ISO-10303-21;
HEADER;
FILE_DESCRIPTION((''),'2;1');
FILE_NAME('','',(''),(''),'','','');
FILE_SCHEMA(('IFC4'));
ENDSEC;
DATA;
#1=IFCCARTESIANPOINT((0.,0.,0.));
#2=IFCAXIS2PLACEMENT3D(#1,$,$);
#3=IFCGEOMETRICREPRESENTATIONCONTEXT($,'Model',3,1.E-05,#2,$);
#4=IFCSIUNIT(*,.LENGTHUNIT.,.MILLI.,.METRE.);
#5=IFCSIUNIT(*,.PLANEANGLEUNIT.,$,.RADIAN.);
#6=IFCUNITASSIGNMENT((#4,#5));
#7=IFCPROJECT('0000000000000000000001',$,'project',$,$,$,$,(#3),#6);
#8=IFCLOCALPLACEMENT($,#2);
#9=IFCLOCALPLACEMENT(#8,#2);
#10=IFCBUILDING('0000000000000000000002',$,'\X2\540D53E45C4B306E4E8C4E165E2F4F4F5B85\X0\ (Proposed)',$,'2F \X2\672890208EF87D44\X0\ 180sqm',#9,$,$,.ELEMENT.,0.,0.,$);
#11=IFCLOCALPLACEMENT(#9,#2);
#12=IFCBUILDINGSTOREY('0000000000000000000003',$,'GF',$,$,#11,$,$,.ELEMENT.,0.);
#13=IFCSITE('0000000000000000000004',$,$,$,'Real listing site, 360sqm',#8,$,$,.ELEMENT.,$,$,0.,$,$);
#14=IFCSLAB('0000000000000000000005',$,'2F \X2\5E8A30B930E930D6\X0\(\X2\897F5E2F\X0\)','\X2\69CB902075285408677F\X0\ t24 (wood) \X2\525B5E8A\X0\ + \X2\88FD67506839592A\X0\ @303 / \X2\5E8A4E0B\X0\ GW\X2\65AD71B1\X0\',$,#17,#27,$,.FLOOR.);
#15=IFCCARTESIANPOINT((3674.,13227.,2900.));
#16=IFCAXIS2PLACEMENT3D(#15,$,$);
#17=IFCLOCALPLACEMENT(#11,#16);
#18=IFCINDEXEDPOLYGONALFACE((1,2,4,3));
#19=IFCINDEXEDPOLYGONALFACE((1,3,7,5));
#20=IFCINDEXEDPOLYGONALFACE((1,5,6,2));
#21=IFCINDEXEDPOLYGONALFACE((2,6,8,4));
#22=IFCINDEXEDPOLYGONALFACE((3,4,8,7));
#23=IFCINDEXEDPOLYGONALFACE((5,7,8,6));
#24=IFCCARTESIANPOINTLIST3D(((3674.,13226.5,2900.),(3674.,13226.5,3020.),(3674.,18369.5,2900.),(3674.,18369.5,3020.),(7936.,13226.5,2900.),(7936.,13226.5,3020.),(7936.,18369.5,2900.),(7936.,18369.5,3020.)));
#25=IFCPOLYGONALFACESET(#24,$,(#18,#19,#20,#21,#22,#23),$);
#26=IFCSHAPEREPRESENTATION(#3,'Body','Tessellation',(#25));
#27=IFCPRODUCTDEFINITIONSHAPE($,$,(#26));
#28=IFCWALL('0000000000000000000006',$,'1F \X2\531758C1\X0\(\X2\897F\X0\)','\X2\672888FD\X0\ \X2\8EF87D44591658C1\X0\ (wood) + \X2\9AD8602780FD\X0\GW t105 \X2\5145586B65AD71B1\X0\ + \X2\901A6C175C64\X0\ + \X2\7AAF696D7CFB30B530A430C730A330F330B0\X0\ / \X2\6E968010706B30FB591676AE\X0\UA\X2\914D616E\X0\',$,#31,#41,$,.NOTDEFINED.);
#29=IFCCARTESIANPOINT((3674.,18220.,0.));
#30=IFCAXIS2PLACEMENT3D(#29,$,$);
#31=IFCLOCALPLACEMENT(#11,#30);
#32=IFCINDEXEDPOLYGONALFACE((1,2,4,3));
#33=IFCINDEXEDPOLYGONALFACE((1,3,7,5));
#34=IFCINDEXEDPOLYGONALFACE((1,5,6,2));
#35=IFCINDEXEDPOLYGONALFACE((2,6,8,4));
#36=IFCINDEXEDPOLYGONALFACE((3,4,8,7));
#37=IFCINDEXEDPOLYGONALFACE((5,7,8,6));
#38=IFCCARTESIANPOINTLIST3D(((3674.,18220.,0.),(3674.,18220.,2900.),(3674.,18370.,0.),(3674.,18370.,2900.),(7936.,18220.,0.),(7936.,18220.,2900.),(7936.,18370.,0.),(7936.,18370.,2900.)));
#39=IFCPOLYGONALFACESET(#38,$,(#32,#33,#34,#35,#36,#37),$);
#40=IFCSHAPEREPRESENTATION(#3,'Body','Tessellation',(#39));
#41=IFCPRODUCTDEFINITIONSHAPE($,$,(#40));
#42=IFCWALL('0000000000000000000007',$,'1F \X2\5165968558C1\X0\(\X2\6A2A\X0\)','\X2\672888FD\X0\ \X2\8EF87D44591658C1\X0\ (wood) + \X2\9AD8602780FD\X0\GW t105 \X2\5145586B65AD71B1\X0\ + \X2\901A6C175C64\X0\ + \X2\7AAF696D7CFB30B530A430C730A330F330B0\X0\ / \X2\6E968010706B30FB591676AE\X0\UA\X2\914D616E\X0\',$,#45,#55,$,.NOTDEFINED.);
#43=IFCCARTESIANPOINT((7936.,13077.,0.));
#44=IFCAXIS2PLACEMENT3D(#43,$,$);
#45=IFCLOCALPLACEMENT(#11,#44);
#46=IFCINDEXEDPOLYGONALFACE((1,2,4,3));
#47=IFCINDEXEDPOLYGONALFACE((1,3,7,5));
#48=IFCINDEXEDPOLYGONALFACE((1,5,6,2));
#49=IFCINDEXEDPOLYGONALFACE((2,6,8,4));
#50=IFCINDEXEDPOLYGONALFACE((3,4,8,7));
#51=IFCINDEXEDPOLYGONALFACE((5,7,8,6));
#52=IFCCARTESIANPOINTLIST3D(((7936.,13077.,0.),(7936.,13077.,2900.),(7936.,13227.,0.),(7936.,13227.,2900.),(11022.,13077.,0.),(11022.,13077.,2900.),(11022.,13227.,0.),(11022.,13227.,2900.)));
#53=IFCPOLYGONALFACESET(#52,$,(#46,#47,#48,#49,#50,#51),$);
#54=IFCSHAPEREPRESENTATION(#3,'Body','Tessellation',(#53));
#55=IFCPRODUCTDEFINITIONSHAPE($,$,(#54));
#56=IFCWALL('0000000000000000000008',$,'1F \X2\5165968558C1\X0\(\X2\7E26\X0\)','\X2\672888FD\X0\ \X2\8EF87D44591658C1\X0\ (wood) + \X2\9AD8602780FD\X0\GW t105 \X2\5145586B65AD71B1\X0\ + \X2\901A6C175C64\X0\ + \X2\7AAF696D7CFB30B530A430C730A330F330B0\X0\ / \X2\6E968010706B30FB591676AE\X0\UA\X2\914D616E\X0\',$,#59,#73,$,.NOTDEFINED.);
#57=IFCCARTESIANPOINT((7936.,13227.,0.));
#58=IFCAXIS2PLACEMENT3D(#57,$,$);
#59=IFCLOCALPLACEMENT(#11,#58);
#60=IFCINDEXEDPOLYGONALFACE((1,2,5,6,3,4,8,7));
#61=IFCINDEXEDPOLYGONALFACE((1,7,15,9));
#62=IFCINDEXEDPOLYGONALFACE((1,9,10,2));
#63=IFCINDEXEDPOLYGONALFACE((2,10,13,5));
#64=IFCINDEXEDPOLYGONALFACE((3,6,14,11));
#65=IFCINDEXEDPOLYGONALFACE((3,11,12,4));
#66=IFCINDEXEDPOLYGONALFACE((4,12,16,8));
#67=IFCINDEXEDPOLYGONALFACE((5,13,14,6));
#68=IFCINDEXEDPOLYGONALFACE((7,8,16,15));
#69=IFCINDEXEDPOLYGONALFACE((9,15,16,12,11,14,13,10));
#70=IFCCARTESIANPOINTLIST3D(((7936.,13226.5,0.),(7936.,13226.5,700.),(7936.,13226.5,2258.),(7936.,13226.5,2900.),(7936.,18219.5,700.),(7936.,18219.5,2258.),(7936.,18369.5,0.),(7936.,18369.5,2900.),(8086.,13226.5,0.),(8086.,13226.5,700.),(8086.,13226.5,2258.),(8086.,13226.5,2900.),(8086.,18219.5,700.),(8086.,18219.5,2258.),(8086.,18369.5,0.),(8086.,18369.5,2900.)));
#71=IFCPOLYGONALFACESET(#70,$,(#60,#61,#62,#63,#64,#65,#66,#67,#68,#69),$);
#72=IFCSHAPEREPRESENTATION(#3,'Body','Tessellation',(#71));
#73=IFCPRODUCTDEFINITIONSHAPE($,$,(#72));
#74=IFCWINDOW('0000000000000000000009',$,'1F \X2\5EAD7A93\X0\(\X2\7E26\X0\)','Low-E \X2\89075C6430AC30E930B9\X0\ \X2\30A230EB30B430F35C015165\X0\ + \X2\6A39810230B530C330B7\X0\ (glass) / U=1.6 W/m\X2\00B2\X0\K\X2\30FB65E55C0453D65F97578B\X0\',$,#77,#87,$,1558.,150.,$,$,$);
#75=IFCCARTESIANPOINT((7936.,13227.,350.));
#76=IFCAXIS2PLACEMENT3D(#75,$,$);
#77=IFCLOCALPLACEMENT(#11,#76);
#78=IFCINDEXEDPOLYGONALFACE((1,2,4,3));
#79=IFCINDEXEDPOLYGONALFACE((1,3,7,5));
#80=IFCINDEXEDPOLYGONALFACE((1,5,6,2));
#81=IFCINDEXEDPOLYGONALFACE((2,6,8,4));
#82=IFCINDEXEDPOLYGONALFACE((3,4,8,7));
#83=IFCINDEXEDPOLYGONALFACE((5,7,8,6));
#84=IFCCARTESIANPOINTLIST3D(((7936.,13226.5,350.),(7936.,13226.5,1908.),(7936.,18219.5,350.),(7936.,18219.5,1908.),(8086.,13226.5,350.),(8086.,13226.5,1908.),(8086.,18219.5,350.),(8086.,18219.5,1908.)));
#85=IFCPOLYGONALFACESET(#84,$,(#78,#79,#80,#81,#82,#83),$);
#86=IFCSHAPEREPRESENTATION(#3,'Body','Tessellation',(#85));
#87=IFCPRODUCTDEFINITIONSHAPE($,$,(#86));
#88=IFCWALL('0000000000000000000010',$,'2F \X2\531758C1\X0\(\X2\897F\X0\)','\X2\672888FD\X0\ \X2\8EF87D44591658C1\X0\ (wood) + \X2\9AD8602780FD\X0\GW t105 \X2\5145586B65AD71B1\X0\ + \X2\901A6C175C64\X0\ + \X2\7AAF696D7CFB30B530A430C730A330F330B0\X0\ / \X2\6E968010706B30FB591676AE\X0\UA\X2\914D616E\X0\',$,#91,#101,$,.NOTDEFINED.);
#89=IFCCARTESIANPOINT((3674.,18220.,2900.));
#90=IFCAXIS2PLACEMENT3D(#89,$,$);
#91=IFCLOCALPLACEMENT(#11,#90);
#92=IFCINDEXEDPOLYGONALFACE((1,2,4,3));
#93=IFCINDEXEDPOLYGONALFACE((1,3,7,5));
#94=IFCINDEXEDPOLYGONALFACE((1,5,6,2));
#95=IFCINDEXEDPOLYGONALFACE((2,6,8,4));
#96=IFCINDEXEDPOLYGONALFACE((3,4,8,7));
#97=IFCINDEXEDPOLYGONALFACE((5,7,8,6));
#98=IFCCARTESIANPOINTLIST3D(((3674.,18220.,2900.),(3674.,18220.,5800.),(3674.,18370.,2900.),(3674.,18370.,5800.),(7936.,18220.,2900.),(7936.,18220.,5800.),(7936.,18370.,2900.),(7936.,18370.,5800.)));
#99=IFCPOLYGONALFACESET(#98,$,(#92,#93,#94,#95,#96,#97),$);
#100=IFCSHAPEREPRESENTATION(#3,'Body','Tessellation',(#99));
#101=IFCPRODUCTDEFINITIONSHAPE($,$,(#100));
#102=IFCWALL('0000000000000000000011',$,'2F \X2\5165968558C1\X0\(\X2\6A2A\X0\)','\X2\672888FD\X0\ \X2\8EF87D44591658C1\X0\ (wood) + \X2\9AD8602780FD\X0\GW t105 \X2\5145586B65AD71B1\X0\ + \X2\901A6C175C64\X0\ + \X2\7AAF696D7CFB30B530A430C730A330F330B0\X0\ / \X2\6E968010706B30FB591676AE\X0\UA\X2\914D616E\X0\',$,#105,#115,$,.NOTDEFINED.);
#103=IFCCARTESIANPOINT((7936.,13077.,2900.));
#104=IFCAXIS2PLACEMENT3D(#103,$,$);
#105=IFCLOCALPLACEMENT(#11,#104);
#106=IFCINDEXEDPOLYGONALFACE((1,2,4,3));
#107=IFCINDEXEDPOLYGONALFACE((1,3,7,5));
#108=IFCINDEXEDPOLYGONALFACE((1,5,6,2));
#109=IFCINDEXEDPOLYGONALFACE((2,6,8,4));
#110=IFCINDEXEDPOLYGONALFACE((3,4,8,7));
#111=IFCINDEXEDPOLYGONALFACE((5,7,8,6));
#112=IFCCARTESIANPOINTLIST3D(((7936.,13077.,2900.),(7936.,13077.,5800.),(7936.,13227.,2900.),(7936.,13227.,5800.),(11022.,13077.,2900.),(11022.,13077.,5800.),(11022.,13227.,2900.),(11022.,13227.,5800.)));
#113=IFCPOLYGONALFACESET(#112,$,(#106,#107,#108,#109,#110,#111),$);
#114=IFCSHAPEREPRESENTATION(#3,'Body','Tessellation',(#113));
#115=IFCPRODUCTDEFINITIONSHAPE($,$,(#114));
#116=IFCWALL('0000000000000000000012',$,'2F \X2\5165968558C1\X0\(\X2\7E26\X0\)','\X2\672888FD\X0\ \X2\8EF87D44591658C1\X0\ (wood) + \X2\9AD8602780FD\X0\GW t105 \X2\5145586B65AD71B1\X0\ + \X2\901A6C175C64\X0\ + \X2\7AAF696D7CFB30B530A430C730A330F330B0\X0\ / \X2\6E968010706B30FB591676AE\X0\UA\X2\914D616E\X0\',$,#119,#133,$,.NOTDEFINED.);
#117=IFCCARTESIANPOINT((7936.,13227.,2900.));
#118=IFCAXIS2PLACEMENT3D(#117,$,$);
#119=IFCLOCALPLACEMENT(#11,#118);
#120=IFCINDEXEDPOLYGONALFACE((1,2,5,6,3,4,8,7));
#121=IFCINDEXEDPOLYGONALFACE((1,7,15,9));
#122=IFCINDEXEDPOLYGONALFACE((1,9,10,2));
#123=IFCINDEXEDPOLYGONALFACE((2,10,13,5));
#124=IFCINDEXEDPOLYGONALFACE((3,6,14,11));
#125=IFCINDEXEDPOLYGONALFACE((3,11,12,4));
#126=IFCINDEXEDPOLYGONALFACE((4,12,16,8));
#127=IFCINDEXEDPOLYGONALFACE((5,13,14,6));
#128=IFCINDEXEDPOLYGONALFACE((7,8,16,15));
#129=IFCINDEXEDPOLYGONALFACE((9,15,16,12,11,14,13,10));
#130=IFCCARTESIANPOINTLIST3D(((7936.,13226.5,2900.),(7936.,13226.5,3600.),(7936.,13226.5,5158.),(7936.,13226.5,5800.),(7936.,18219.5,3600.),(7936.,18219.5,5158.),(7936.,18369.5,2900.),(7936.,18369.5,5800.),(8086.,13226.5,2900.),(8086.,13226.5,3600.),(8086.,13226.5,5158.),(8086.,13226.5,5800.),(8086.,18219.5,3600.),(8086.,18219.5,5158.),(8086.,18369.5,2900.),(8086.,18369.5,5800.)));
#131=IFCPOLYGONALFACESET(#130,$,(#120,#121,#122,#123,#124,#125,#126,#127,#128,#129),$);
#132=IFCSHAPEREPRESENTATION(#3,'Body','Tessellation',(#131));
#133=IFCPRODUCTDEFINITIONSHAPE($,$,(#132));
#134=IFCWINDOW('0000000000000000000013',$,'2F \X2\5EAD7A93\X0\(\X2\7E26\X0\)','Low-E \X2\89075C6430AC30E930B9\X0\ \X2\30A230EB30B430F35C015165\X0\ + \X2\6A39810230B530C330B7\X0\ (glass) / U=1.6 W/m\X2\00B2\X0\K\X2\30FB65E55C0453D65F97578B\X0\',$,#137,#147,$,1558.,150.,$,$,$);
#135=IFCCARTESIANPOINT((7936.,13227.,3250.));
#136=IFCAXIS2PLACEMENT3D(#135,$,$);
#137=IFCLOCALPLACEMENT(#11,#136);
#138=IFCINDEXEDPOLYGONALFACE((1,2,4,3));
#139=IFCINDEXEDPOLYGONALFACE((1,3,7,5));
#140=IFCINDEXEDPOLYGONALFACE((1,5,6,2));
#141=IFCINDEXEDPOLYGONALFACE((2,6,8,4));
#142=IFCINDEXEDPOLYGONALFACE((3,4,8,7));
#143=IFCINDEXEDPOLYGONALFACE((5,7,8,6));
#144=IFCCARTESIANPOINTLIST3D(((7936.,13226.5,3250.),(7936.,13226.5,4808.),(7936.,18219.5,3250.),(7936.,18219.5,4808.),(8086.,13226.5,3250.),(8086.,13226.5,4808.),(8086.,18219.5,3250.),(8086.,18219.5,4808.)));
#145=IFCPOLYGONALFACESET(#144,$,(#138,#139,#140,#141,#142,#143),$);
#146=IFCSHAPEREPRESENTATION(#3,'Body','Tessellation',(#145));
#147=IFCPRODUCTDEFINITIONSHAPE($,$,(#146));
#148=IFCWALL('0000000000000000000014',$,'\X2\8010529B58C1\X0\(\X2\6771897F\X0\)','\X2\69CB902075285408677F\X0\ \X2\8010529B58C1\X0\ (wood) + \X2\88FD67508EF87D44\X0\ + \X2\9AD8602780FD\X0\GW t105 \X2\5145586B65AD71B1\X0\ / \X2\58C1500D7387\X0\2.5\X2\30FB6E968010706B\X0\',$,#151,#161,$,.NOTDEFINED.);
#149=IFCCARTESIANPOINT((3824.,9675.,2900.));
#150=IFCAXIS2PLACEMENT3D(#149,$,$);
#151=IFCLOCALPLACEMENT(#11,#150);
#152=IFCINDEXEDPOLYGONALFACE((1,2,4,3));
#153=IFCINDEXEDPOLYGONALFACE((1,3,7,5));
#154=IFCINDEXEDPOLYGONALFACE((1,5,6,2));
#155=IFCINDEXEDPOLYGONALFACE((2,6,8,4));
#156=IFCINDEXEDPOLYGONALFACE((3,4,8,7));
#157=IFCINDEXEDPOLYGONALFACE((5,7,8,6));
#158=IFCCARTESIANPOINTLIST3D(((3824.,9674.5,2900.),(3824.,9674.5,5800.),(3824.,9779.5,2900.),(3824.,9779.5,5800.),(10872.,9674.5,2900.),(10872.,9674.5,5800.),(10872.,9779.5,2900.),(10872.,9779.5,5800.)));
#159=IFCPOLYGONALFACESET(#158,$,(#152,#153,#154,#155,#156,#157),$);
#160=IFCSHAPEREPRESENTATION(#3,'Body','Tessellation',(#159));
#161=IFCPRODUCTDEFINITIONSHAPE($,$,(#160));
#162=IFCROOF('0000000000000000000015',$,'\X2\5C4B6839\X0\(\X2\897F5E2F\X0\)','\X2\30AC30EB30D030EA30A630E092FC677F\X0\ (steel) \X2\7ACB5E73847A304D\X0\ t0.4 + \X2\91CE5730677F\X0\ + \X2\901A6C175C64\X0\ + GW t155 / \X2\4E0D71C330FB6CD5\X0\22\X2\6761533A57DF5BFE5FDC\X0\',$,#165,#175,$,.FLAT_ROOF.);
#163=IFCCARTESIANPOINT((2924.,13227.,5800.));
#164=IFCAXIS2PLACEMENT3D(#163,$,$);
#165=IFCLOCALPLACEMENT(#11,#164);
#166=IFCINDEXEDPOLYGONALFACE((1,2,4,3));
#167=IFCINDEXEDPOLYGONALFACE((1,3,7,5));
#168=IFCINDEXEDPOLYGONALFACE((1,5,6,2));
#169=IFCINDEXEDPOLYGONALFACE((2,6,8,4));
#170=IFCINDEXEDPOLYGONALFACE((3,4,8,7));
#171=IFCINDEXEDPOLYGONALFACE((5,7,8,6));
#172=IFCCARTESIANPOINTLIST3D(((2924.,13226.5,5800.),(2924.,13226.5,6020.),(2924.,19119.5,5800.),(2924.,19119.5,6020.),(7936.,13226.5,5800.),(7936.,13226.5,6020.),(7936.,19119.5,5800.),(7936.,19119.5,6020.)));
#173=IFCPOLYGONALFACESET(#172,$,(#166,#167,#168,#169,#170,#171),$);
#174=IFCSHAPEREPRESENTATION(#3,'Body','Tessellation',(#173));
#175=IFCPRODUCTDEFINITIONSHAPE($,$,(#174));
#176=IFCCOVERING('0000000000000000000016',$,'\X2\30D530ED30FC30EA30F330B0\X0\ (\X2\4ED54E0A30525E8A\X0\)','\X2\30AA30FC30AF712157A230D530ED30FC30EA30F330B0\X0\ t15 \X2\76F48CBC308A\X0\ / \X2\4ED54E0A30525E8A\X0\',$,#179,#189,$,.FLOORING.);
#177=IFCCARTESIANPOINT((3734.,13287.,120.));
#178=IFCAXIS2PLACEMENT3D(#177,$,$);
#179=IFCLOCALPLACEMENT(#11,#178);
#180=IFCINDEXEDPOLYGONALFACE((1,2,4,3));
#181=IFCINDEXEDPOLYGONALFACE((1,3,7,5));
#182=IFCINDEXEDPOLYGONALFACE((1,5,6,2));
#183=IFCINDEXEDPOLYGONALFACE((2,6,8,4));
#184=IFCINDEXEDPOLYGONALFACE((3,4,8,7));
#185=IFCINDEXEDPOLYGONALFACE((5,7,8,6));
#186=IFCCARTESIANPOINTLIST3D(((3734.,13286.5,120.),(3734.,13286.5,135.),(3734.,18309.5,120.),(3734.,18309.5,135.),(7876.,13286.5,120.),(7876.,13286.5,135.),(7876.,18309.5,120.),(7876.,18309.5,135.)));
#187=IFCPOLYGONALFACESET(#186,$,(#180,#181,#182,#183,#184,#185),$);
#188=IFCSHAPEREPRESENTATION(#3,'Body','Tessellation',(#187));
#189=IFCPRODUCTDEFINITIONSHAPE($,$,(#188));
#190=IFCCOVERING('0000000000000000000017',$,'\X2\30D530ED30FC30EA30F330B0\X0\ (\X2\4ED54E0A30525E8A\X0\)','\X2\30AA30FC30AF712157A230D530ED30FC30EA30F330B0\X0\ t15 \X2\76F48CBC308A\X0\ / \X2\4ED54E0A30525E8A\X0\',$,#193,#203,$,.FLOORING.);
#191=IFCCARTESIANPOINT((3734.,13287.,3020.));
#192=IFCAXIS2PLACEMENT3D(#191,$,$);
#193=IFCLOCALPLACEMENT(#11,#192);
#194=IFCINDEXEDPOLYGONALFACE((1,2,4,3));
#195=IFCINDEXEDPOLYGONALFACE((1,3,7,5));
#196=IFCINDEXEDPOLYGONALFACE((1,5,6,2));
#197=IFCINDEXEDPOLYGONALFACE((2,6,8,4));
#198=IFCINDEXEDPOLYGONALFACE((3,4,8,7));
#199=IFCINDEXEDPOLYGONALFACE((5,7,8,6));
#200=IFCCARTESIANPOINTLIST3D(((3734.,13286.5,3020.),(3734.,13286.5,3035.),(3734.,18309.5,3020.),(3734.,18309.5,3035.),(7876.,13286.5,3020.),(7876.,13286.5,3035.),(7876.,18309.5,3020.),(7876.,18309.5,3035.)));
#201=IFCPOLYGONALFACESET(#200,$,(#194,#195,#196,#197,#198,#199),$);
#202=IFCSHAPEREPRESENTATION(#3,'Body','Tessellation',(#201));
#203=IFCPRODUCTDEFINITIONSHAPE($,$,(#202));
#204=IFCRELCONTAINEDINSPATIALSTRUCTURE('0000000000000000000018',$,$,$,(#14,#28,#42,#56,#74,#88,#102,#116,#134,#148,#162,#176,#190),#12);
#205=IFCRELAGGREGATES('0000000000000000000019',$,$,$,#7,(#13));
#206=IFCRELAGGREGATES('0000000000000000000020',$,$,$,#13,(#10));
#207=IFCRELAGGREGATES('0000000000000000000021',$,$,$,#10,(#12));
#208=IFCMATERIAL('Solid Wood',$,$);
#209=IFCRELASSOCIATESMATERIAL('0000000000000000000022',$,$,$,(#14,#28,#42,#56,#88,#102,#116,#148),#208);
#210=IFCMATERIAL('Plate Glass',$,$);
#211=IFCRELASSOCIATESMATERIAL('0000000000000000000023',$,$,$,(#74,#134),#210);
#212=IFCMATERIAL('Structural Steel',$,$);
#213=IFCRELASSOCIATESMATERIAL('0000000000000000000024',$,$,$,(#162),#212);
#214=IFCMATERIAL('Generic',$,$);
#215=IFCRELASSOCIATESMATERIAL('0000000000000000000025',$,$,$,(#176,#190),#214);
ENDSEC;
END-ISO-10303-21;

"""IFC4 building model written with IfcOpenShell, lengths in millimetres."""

from ifc_helpers import new_model, si_unit, frame, frame_2d, origin, place, context, project, spatial, rectangle, extrude, material, element, fill, save


model = new_model("IFC4")

# Units and contexts
model_context = context("Model", 3, precision=1e-05, world=origin())
ifc_project = project(units=[si_unit("LENGTHUNIT", "METRE", prefix="MILLI"), si_unit("PLANEANGLEUNIT", "RADIAN")], contexts=[model_context])

# Site, building, storey
site_placement = place(None, origin())
site = spatial("IfcSite", under=ifc_project, at=site_placement, ObjectType="Real listing site, 360sqm", CompositionType="ELEMENT", RefElevation=0.0)
building_placement = place(site_placement, origin())
building = spatial("IfcBuilding", under=site, at=building_placement, Name="名古屋の二世帯住宅 (Proposed)", ObjectType="2F 木造軸組 180sqm", CompositionType="ELEMENT", ElevationOfRefHeight=0.0, ElevationOfTerrain=0.0)
storey_placement = place(building_placement, origin())
storey = spatial("IfcBuildingStorey", under=building, at=storey_placement, Name="GF", CompositionType="ELEMENT", Elevation=0.0)

# Slab
ifc_material_1 = material(Name="Solid Wood")
slab_1_placement = place(storey_placement, frame((3674.0, 13227.0, 2900.0)))
element("IfcSlab", 1, at=slab_1_placement, inside=storey, material=ifc_material_1, Name="2F 床スラブ(西帯)", Description="構造用合板 t24 (wood) 剛床 + 製材根太 @303 / 床下 GW断熱", PredefinedType="FLOOR", context=model_context, shape_type="SweptSolid", body=[
    extrude(rectangle(XDim=4262.0, YDim=5143.0, at=frame_2d((2131.0, 2571.0))), frame((3674.0, 13227.0, 2900.0)), (0.0, 0.0, 1.0), 120.0),
])

# Walls
wall_1_placement = place(storey_placement, frame((3674.0, 18220.0, 0.0)))
element("IfcWall", 2, at=wall_1_placement, inside=storey, material=ifc_material_1, Name="1F 北壁(西)", Description="木製 軸組外壁 (wood) + 高性能GW t105 充填断熱 + 通気層 + 窯業系サイディング / 準耐火・外皮UA配慮", PredefinedType="NOTDEFINED", context=model_context, shape_type="SweptSolid", body=[
    extrude(rectangle(XDim=4262.0, YDim=150.0, at=frame_2d((2131.0, 75.0))), frame((3674.0, 18220.0, 0.0)), (0.0, 0.0, 1.0), 2900.0),
])
wall_2_placement = place(storey_placement, frame((7936.0, 13077.0, 0.0)))
element("IfcWall", 3, at=wall_2_placement, inside=storey, material=ifc_material_1, Name="1F 入隅壁(横)", Description="木製 軸組外壁 (wood) + 高性能GW t105 充填断熱 + 通気層 + 窯業系サイディング / 準耐火・外皮UA配慮", PredefinedType="NOTDEFINED", context=model_context, shape_type="SweptSolid", body=[
    extrude(rectangle(XDim=3086.0, YDim=150.0, at=frame_2d((1543.0, 75.0))), frame((7936.0, 13077.0, 0.0)), (0.0, 0.0, 1.0), 2900.0),
])

# Wall, opening, window
wall_3_placement = place(storey_placement, frame((7936.0, 13227.0, 0.0)))
wall_3 = element("IfcWall", 4, at=wall_3_placement, inside=storey, material=ifc_material_1, Name="1F 入隅壁(縦)", Description="木製 軸組外壁 (wood) + 高性能GW t105 充填断熱 + 通気層 + 窯業系サイディング / 準耐火・外皮UA配慮", PredefinedType="NOTDEFINED", context=model_context, shape_type="SweptSolid", body=[
    extrude(rectangle(XDim=150.0, YDim=5143.0, at=frame_2d((75.0, 2571.0))), frame((7936.0, 13227.0, 0.0)), (0.0, 0.0, 1.0), 2900.0),
])
opening_1_placement = place(storey_placement, frame((7936.0, 13227.0, 350.0)))
opening_1 = element("IfcOpeningElement", 5, at=opening_1_placement, cuts=wall_3, PredefinedType="NOTDEFINED", context=model_context, shape_type="SweptSolid", body=[
    extrude(rectangle(XDim=150.0, YDim=4993.0, at=frame_2d((75.0, 2496.0))), frame((7936.0, 13227.0, 350.0)), (0.0, 0.0, 1.0), 1558.0),
])
ifc_material_2 = material(Name="Plate Glass")
window_1_placement = place(storey_placement, frame((7936.0, 13227.0, 350.0)))
window_1 = element("IfcWindow", 6, at=window_1_placement, inside=storey, material=ifc_material_2, Name="1F 庭窓(縦)", Description="Low-E 複層ガラス アルゴン封入 + 樹脂サッシ (glass) / U=1.6 W/m²K・日射取得型", OverallHeight=1558.0, OverallWidth=150.0, context=model_context, shape_type="SweptSolid", body=[
    extrude(rectangle(XDim=150.0, YDim=4993.0, at=frame_2d((75.0, 2496.0))), frame((7936.0, 13227.0, 350.0)), (0.0, 0.0, 1.0), 1558.0),
])
fill(opening_1, window_1)

# Walls
wall_4_placement = place(storey_placement, frame((3674.0, 18220.0, 2900.0)))
element("IfcWall", 7, at=wall_4_placement, inside=storey, material=ifc_material_1, Name="2F 北壁(西)", Description="木製 軸組外壁 (wood) + 高性能GW t105 充填断熱 + 通気層 + 窯業系サイディング / 準耐火・外皮UA配慮", PredefinedType="NOTDEFINED", context=model_context, shape_type="SweptSolid", body=[
    extrude(rectangle(XDim=4262.0, YDim=150.0, at=frame_2d((2131.0, 75.0))), frame((3674.0, 18220.0, 2900.0)), (0.0, 0.0, 1.0), 2900.0),
])
wall_5_placement = place(storey_placement, frame((7936.0, 13077.0, 2900.0)))
element("IfcWall", 8, at=wall_5_placement, inside=storey, material=ifc_material_1, Name="2F 入隅壁(横)", Description="木製 軸組外壁 (wood) + 高性能GW t105 充填断熱 + 通気層 + 窯業系サイディング / 準耐火・外皮UA配慮", PredefinedType="NOTDEFINED", context=model_context, shape_type="SweptSolid", body=[
    extrude(rectangle(XDim=3086.0, YDim=150.0, at=frame_2d((1543.0, 75.0))), frame((7936.0, 13077.0, 2900.0)), (0.0, 0.0, 1.0), 2900.0),
])

# Wall, opening, window
wall_6_placement = place(storey_placement, frame((7936.0, 13227.0, 2900.0)))
wall_6 = element("IfcWall", 9, at=wall_6_placement, inside=storey, material=ifc_material_1, Name="2F 入隅壁(縦)", Description="木製 軸組外壁 (wood) + 高性能GW t105 充填断熱 + 通気層 + 窯業系サイディング / 準耐火・外皮UA配慮", PredefinedType="NOTDEFINED", context=model_context, shape_type="SweptSolid", body=[
    extrude(rectangle(XDim=150.0, YDim=5143.0, at=frame_2d((75.0, 2571.0))), frame((7936.0, 13227.0, 2900.0)), (0.0, 0.0, 1.0), 2900.0),
])
opening_2_placement = place(storey_placement, frame((7936.0, 13227.0, 3250.0)))
opening_2 = element("IfcOpeningElement", 10, at=opening_2_placement, cuts=wall_6, PredefinedType="NOTDEFINED", context=model_context, shape_type="SweptSolid", body=[
    extrude(rectangle(XDim=150.0, YDim=4993.0, at=frame_2d((75.0, 2496.0))), frame((7936.0, 13227.0, 3250.0)), (0.0, 0.0, 1.0), 1558.0),
])
window_2_placement = place(storey_placement, frame((7936.0, 13227.0, 3250.0)))
window_2 = element("IfcWindow", 11, at=window_2_placement, inside=storey, material=ifc_material_2, Name="2F 庭窓(縦)", Description="Low-E 複層ガラス アルゴン封入 + 樹脂サッシ (glass) / U=1.6 W/m²K・日射取得型", OverallHeight=1558.0, OverallWidth=150.0, context=model_context, shape_type="SweptSolid", body=[
    extrude(rectangle(XDim=150.0, YDim=4993.0, at=frame_2d((75.0, 2496.0))), frame((7936.0, 13227.0, 3250.0)), (0.0, 0.0, 1.0), 1558.0),
])
fill(opening_2, window_2)

# Wall
wall_7_placement = place(storey_placement, frame((3824.0, 9675.0, 2900.0)))
element("IfcWall", 12, at=wall_7_placement, inside=storey, material=ifc_material_1, Name="耐力壁(東西)", Description="構造用合板 耐力壁 (wood) + 製材軸組 + 高性能GW t105 充填断熱 / 壁倍率2.5・準耐火", PredefinedType="NOTDEFINED", context=model_context, shape_type="SweptSolid", body=[
    extrude(rectangle(XDim=7048.0, YDim=105.0, at=frame_2d((3524.0, 52.0))), frame((3824.0, 9675.0, 2900.0)), (0.0, 0.0, 1.0), 2900.0),
])

# Roof
ifc_material_3 = material(Name="Structural Steel")
for number, where, name in (
    (13, (2924.0, 13227.0, 5800.0), "屋根(西帯)"),
):
    element("IfcRoof", number, at=place(storey_placement, frame(where)), inside=storey, material=ifc_material_3, Name=name, Description="ガルバリウム鋼板 (steel) 立平葺き t0.4 + 野地板 + 通気層 + GW t155 / 不燃・法22条区域対応", PredefinedType="FLAT_ROOF", context=model_context, shape_type="SweptSolid", body=[
        extrude(rectangle(XDim=5012.0, YDim=5893.0, at=frame_2d((2506.0, 2946.0))), frame((2924.0, 13227.0, 5800.0)), (0.0, 0.0, 1.0), 220.0),
    ])

# Coverings
ifc_material_4 = material(Name="Generic")
covering_1_placement = place(storey_placement, frame((3734.0, 13287.0, 120.0)))
element("IfcCovering", 14, at=covering_1_placement, inside=storey, material=ifc_material_4, Name="フローリング (仕上げ床)", Description="オーク無垢フローリング t15 直貼り / 仕上げ床", PredefinedType="FLOORING", context=model_context, shape_type="SweptSolid", body=[
    extrude(rectangle(XDim=4142.0, YDim=5023.0, at=frame_2d((2071.0, 2511.0))), frame((3734.0, 13287.0, 120.0)), (0.0, 0.0, 1.0), 15.0),
])
covering_2_placement = place(storey_placement, frame((3734.0, 13287.0, 3020.0)))
element("IfcCovering", 15, at=covering_2_placement, inside=storey, material=ifc_material_4, Name="フローリング (仕上げ床)", Description="オーク無垢フローリング t15 直貼り / 仕上げ床", PredefinedType="FLOORING", context=model_context, shape_type="SweptSolid", body=[
    extrude(rectangle(XDim=4142.0, YDim=5023.0, at=frame_2d((2071.0, 2511.0))), frame((3734.0, 13287.0, 3020.0)), (0.0, 0.0, 1.0), 15.0),
])

save(model, "model.ifc")
